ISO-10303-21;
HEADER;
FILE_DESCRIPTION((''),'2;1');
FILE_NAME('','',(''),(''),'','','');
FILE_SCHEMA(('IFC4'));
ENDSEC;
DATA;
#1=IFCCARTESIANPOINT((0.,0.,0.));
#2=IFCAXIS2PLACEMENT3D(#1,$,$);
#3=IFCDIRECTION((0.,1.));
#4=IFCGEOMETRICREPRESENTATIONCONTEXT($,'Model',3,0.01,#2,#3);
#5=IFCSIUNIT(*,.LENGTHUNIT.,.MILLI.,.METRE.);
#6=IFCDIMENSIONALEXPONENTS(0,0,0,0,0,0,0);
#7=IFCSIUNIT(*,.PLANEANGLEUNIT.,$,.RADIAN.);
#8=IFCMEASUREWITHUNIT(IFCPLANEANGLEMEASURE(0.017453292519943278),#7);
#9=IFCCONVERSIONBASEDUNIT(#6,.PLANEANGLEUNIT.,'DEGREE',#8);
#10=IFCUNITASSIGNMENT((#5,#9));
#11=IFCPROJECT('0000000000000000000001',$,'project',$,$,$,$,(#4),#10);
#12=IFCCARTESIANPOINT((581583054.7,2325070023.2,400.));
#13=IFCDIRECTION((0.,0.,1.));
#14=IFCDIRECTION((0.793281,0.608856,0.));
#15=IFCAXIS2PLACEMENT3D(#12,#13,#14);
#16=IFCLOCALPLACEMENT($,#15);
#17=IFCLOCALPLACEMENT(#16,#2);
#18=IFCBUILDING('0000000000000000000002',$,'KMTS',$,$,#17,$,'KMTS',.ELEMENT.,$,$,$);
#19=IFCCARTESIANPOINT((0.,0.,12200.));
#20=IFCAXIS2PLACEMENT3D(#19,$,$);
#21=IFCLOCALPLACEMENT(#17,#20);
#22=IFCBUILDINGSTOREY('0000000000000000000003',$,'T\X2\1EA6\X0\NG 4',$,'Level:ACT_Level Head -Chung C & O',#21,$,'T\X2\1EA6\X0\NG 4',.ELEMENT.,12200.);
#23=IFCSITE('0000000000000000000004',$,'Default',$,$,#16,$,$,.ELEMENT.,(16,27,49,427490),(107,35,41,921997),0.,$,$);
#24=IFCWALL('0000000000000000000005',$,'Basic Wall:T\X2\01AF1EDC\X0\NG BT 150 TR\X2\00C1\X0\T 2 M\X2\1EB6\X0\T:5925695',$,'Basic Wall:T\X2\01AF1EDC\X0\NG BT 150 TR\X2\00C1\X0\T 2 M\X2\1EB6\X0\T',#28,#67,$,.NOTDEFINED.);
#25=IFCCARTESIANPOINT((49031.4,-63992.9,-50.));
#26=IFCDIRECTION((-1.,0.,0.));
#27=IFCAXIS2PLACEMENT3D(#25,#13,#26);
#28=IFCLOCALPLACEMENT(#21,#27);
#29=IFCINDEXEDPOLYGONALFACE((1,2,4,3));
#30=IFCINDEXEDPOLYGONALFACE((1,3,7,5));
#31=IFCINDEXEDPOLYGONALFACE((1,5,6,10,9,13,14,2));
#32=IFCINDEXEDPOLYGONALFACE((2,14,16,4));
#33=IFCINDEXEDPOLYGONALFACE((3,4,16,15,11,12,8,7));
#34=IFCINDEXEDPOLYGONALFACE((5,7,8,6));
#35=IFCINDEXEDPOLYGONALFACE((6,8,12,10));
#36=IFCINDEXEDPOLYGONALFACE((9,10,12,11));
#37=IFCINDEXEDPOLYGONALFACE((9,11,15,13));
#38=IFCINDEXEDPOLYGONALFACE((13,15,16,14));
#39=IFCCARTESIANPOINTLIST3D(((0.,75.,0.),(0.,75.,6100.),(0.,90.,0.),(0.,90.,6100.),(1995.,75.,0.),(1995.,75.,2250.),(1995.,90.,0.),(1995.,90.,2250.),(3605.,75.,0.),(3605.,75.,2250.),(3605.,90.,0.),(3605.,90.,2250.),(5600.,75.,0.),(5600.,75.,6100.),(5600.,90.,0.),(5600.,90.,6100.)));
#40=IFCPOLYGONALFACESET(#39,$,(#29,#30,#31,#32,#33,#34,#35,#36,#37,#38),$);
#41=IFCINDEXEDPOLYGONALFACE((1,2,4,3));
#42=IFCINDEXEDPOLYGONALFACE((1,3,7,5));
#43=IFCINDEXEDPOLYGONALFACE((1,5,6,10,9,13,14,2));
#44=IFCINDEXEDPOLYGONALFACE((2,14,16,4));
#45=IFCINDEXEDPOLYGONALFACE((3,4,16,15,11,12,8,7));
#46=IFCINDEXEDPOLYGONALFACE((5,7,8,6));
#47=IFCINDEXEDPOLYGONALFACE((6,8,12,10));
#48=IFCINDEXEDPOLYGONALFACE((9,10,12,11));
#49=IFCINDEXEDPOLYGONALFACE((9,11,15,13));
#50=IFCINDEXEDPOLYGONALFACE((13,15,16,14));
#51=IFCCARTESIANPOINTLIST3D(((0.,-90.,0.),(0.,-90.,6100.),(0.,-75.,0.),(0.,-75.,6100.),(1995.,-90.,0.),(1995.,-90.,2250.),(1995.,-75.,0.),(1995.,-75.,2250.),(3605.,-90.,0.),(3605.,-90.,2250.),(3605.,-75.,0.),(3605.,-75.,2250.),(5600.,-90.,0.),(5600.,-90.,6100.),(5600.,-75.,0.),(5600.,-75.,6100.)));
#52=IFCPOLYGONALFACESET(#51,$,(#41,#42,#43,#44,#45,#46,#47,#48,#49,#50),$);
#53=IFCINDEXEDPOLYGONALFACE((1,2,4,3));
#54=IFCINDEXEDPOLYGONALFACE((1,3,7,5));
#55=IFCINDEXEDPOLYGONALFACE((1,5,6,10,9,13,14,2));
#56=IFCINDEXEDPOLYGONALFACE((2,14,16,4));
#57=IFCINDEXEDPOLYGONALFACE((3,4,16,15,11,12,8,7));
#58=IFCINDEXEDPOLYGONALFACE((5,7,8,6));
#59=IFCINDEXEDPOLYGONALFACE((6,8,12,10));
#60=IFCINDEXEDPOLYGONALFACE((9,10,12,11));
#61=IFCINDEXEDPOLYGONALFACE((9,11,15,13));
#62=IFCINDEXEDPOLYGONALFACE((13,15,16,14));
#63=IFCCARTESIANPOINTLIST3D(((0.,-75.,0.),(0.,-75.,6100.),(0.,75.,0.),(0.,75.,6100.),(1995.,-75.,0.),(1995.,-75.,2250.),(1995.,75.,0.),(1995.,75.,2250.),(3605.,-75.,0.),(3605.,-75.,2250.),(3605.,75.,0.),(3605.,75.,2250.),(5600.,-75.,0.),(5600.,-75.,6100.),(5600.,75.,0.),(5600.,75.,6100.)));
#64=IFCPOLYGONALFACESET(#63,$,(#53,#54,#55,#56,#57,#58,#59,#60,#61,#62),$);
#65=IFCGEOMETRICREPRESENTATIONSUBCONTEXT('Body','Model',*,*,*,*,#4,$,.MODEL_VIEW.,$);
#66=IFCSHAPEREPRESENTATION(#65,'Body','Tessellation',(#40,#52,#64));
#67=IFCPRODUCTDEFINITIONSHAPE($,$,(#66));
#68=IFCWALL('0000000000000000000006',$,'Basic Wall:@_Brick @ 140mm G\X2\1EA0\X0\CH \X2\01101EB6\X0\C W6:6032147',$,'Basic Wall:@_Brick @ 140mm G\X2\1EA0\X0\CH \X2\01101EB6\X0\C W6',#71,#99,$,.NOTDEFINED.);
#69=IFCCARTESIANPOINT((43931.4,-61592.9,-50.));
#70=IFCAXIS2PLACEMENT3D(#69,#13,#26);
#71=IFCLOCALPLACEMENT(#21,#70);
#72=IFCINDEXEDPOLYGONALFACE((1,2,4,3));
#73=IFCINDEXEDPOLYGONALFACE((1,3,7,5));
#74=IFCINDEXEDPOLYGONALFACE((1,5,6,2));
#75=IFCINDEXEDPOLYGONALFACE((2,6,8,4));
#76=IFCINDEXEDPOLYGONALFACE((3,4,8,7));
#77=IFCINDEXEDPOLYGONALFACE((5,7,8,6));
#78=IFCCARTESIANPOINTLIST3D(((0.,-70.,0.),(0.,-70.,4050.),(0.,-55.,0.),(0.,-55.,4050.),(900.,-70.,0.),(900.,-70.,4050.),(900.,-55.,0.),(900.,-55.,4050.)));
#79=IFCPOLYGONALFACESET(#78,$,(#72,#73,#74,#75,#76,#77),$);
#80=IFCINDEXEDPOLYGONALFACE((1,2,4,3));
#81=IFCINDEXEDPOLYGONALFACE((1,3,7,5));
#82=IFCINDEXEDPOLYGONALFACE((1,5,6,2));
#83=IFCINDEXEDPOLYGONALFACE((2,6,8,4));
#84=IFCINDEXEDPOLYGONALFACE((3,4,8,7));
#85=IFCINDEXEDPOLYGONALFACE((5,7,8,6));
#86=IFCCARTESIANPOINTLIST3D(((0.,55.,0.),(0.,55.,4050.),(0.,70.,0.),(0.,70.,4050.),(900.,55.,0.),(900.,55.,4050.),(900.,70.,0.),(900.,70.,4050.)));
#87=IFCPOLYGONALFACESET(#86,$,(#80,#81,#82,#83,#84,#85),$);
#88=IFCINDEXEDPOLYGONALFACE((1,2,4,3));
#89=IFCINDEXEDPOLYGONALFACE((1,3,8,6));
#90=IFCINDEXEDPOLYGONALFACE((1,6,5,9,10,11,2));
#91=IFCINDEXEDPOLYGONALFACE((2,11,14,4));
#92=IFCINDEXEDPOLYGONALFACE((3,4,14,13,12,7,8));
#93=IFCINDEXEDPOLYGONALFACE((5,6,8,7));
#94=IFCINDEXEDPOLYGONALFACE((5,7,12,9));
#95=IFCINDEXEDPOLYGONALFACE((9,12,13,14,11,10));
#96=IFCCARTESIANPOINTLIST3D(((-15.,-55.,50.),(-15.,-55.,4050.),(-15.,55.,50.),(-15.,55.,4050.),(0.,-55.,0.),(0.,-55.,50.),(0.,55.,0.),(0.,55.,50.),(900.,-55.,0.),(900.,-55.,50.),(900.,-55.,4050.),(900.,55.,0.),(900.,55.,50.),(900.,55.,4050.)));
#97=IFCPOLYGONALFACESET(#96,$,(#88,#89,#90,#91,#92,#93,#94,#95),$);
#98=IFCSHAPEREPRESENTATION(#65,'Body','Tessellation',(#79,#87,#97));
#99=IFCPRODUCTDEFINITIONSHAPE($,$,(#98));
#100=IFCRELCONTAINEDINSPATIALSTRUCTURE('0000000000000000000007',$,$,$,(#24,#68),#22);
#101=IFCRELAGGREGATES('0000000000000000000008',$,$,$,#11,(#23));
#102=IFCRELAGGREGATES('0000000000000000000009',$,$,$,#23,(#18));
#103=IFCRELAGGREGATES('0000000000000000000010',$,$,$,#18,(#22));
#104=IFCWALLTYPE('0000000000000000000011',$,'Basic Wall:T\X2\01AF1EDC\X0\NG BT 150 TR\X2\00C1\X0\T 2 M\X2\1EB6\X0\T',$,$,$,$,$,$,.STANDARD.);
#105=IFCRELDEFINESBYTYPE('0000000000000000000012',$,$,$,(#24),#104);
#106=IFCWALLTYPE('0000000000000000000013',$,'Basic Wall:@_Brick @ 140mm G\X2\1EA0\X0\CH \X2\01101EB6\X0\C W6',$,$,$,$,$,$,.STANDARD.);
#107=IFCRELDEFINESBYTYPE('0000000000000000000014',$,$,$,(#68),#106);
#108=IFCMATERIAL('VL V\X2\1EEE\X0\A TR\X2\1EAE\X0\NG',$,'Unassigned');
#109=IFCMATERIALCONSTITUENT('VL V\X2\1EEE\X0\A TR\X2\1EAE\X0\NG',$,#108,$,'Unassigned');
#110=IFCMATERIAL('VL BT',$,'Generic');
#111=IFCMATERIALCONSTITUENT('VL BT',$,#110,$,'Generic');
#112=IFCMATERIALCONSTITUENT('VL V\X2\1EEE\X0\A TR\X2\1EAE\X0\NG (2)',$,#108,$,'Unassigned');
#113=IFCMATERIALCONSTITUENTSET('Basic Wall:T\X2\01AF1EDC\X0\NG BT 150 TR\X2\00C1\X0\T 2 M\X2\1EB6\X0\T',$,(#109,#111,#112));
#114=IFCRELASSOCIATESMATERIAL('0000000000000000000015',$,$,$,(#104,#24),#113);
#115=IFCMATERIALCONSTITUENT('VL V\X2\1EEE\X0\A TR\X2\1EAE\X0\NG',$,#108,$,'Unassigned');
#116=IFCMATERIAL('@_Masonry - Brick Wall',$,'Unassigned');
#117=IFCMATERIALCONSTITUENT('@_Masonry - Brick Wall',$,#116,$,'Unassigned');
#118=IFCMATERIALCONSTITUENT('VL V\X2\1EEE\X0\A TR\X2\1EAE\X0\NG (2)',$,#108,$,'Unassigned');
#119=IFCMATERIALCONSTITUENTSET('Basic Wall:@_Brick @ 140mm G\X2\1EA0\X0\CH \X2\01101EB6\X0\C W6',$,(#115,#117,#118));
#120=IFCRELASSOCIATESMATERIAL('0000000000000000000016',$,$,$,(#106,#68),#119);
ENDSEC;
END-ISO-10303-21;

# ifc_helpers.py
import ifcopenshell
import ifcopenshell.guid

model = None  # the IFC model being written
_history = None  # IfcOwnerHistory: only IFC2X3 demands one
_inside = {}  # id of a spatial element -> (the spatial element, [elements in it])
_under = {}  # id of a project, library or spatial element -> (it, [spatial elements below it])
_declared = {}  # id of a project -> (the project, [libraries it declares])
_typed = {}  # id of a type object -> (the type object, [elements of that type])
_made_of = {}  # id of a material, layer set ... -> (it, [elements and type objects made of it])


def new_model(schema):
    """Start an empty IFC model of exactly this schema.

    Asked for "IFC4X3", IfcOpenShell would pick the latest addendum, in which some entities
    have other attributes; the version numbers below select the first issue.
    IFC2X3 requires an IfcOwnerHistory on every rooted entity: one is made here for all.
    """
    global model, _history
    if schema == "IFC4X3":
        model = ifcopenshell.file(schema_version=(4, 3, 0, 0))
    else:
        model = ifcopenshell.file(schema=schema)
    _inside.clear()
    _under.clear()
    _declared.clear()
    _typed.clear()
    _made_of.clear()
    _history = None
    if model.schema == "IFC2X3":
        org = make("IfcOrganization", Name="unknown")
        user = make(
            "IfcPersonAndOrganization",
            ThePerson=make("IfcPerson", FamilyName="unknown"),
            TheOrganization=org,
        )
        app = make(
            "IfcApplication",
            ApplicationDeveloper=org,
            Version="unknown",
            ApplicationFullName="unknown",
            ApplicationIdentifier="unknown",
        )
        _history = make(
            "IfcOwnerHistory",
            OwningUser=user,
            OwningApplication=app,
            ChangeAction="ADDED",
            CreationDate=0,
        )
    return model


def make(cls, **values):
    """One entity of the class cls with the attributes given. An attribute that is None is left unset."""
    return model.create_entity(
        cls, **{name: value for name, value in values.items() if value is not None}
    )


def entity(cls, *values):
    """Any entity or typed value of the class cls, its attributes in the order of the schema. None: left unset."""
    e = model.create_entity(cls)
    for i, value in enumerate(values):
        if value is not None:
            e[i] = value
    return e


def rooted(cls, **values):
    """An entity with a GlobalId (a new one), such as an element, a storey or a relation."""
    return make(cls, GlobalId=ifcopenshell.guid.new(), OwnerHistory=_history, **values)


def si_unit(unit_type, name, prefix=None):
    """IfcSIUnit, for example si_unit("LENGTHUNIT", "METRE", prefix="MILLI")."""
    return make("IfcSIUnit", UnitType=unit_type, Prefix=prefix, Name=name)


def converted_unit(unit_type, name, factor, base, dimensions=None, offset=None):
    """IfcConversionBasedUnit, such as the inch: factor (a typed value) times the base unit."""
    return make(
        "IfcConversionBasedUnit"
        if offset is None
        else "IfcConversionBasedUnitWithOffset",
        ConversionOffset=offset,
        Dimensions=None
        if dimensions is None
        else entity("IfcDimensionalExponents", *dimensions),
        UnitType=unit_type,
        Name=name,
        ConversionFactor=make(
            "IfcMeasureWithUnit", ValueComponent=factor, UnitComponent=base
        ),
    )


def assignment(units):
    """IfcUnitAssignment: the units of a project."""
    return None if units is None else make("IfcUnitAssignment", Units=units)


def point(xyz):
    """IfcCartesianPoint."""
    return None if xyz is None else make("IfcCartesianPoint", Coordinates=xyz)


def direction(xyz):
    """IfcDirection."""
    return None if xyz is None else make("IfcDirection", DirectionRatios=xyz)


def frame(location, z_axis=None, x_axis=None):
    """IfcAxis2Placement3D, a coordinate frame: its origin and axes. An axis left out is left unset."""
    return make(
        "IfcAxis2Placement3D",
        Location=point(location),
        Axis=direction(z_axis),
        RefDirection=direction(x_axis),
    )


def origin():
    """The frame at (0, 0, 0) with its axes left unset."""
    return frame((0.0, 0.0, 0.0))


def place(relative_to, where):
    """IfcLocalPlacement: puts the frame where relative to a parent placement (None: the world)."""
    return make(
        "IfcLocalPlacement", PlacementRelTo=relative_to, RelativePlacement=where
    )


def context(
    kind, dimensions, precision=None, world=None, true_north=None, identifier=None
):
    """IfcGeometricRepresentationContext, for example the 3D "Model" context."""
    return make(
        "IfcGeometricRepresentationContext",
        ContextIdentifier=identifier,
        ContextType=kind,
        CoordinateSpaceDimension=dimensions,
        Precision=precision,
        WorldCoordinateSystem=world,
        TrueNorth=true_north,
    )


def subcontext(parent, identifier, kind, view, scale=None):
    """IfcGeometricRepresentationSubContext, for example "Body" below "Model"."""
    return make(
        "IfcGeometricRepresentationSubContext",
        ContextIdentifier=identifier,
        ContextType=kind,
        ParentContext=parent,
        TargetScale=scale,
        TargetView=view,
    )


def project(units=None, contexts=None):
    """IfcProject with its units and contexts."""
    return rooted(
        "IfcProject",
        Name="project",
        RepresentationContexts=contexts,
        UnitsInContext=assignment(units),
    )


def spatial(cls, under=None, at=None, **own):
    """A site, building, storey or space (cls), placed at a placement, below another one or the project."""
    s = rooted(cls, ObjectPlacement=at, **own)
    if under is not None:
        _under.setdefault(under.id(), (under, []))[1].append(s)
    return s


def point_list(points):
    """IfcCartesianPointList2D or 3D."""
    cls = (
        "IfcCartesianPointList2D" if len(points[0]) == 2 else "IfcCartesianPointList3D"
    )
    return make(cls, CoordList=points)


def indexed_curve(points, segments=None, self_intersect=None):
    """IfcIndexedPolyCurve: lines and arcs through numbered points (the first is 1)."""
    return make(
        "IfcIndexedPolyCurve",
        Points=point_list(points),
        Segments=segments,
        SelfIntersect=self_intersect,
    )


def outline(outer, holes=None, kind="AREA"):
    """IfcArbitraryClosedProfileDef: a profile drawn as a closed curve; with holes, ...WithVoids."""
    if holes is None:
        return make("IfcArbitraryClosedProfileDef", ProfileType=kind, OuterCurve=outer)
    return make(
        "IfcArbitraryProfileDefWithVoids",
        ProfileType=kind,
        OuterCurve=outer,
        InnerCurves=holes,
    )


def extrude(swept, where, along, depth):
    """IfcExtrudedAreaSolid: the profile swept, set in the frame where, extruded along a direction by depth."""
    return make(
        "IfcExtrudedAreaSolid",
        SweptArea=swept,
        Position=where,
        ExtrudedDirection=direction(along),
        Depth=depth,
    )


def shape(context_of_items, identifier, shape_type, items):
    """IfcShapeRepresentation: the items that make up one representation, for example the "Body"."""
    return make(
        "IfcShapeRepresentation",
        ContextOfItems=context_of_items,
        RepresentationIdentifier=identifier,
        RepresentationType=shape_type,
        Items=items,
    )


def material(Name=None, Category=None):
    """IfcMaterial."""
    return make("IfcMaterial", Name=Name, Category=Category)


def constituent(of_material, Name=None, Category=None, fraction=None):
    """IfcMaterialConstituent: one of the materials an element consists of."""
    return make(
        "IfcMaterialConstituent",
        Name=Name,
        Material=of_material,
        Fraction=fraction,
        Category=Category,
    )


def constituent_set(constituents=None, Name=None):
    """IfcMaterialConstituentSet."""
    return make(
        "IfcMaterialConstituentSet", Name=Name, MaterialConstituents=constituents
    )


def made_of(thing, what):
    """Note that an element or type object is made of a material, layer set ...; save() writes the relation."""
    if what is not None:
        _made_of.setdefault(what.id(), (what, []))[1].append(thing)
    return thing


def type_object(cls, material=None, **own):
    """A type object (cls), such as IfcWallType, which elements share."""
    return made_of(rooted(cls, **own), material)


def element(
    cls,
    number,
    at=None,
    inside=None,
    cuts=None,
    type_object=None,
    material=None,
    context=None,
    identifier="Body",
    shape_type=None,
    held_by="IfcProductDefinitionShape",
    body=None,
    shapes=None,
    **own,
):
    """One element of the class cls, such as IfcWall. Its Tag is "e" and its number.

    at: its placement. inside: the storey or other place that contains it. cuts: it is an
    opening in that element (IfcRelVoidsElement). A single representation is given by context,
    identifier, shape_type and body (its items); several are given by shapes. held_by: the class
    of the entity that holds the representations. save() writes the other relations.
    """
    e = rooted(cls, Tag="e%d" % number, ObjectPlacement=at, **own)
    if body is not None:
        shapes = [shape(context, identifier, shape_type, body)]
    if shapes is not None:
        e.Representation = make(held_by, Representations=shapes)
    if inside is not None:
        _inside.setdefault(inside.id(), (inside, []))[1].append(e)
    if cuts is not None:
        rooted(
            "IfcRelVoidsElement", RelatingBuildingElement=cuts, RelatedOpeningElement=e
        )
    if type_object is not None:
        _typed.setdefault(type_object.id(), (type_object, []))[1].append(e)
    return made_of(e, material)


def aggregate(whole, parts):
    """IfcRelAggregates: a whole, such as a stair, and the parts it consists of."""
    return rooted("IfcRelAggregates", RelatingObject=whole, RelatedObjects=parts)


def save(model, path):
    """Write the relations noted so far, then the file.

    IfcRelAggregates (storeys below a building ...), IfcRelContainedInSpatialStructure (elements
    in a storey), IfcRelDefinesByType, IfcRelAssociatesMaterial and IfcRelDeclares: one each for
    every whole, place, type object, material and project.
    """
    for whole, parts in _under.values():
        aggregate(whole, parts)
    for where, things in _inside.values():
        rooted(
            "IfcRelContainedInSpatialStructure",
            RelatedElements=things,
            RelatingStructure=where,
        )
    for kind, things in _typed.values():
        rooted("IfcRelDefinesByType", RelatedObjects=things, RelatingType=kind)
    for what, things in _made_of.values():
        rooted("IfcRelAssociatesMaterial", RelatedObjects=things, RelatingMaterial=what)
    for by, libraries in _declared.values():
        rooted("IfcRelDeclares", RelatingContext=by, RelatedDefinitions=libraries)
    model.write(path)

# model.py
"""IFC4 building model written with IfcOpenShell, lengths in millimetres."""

from ifc_helpers import new_model, entity, si_unit, converted_unit, direction, frame, origin, place, context, subcontext, project, spatial, indexed_curve, outline, extrude, material, constituent, constituent_set, type_object, element, save


model = new_model("IFC4")

# Units and contexts
model_context = context("Model", 3, precision=0.01, world=origin(), true_north=direction((0.0, 1.0)))
body_context = subcontext(model_context, "Body", "Model", "MODEL_VIEW")
ifc_project = project(units=[si_unit("LENGTHUNIT", "METRE", prefix="MILLI"), converted_unit("PLANEANGLEUNIT", "DEGREE", entity("IfcPlaneAngleMeasure", 0.017453292519943278), si_unit("PLANEANGLEUNIT", "RADIAN"), dimensions=[0, 0, 0, 0, 0, 0, 0])], contexts=[model_context])

# Site, building, storey
site_placement = place(None, frame((581583054.7, 2325070023.2, 400.0), z_axis=(0.0, 0.0, 1.0), x_axis=(0.793281, 0.608856, 0.0)))
site = spatial("IfcSite", under=ifc_project, at=site_placement, Name="Default", CompositionType="ELEMENT", RefLatitude=(16, 27, 49, 427490), RefLongitude=(107, 35, 41, 921997), RefElevation=0.0)
building_placement = place(site_placement, origin())
building = spatial("IfcBuilding", under=site, at=building_placement, Name="KMTS", LongName="KMTS", CompositionType="ELEMENT")
storey_placement = place(building_placement, frame((0.0, 0.0, 12200.0)))
storey = spatial("IfcBuildingStorey", under=building, at=storey_placement, Name="TẦNG 4", ObjectType="Level:ACT_Level Head -Chung C & O", LongName="TẦNG 4", CompositionType="ELEMENT", Elevation=12200.0)

# Shared definitions
ifc_material_1 = material(Name="VL VỮA TRẮNG", Category="Unassigned")
ifc_constituent_1 = constituent(ifc_material_1, Name="VL VỮA TRẮNG", Category="Unassigned")
ifc_material_2 = material(Name="VL BT", Category="Generic")
ifc_constituent_2 = constituent(ifc_material_2, Name="VL BT", Category="Generic")
ifc_constituent_3 = constituent(ifc_material_1, Name="VL VỮA TRẮNG (2)", Category="Unassigned")
ifc_constituent_set_1 = constituent_set(constituents=[ifc_constituent_1, ifc_constituent_2, ifc_constituent_3], Name="Basic Wall:TƯỜNG BT 150 TRÁT 2 MẶT")
wall_type_1 = type_object("IfcWallType", Name="Basic Wall:TƯỜNG BT 150 TRÁT 2 MẶT", PredefinedType="STANDARD", material=ifc_constituent_set_1)

# Wall, opening
wall_1_placement = place(storey_placement, frame((49031.4, -63992.9, -50.0), z_axis=(0.0, 0.0, 1.0), x_axis=(-1.0, 0.0, 0.0)))
wall_1 = element("IfcWall", 1, at=wall_1_placement, inside=storey, type_object=wall_type_1, material=ifc_constituent_set_1, Name="Basic Wall:TƯỜNG BT 150 TRÁT 2 MẶT:5925695", ObjectType="Basic Wall:TƯỜNG BT 150 TRÁT 2 MẶT", PredefinedType="NOTDEFINED", context=body_context, shape_type="SweptSolid", body=[
    extrude(outline(indexed_curve([(-2087.5, -2800.0), (4012.5, -2800.0), (4012.5, 2800.0), (-2087.5, 2800.0), (-2087.5, 805.0), (162.5, 805.0), (162.5, -805.0), (-2087.5, -805.0), (-2087.5, -2800.0)], self_intersect=False)), frame((2800.0, 90.0, 2087.5), z_axis=(0.0, -1.0, 0.0), x_axis=(0.0, 0.0, 1.0)), (0.0, 0.0, 1.0), 15.0),
    extrude(outline(indexed_curve([(-2087.5, -805.0), (-2087.5, -2800.0), (4012.5, -2800.0), (4012.5, 2800.0), (-2087.5, 2800.0), (-2087.5, 805.0), (162.5, 805.0), (162.5, -805.0), (-2087.5, -805.0)], self_intersect=False)), frame((2800.0, -75.0, 2087.5), z_axis=(0.0, 1.0, 0.0), x_axis=(0.0, 0.0, 1.0)), (0.0, 0.0, -1.0), 15.0),
    extrude(outline(indexed_curve([(-2087.5, -805.0), (-2087.5, -2800.0), (4012.5, -2800.0), (4012.5, 2800.0), (-2087.5, 2800.0), (-2087.5, 805.0), (162.5, 805.0), (162.5, -805.0), (-2087.5, -805.0)], self_intersect=False)), frame((2800.0, 75.0, 2087.5), z_axis=(0.0, 1.0, 0.0), x_axis=(0.0, 0.0, 1.0)), (0.0, 0.0, -1.0), 150.0),
])
opening_1_placement = place(wall_1_placement, frame((3605.0, 90.0, 0.0)))
element("IfcOpeningElement", 2, at=opening_1_placement, cuts=wall_1, PredefinedType="OPENING", context=body_context, shape_type="SweptSolid", body=[
    extrude(outline(indexed_curve([(2250.0, 0.0), (2250.0, 1610.0), (0.0, 1610.0), (0.0, 0.0), (2250.0, 0.0)], self_intersect=False)), frame((0.0, 0.0, 0.0), z_axis=(0.0, -1.0, 0.0), x_axis=(0.0, 0.0, 1.0)), (0.0, 0.0, 1.0), 180.0),
])

# Wall
ifc_constituent_4 = constituent(ifc_material_1, Name="VL VỮA TRẮNG", Category="Unassigned")
ifc_material_3 = material(Name="@_Masonry - Brick Wall", Category="Unassigned")
ifc_constituent_5 = constituent(ifc_material_3, Name="@_Masonry - Brick Wall", Category="Unassigned")
ifc_constituent_6 = constituent(ifc_material_1, Name="VL VỮA TRẮNG (2)", Category="Unassigned")
ifc_constituent_set_2 = constituent_set(constituents=[ifc_constituent_4, ifc_constituent_5, ifc_constituent_6], Name="Basic Wall:@_Brick @ 140mm GẠCH ĐẶC W6")
wall_type_2 = type_object("IfcWallType", Name="Basic Wall:@_Brick @ 140mm GẠCH ĐẶC W6", PredefinedType="STANDARD", material=ifc_constituent_set_2)
wall_2_placement = place(storey_placement, frame((43931.4, -61592.9, -50.0), z_axis=(0.0, 0.0, 1.0), x_axis=(-1.0, 0.0, 0.0)))
element("IfcWall", 3, at=wall_2_placement, inside=storey, type_object=wall_type_2, material=ifc_constituent_set_2, Name="Basic Wall:@_Brick @ 140mm GẠCH ĐẶC W6:6032147", ObjectType="Basic Wall:@_Brick @ 140mm GẠCH ĐẶC W6", PredefinedType="NOTDEFINED", context=body_context, shape_type="SweptSolid", body=[
    extrude(outline(indexed_curve([(-7.5, -450.0), (7.5, -450.0), (7.5, 450.0), (-7.5, 450.0), (-7.5, -450.0)], self_intersect=False)), frame((450.0, -62.5, 0.0), z_axis=(0.0, 0.0, 1.0), x_axis=(0.0, 1.0, 0.0)), (0.0, 0.0, 1.0), 4050.0),
    extrude(outline(indexed_curve([(-7.5, -450.0), (7.5, -450.0), (7.5, 450.0), (-7.5, 450.0), (-7.5, -450.0)], self_intersect=False)), frame((450.0, 62.5, 0.0), z_axis=(0.0, 0.0, 1.0), x_axis=(0.0, -1.0, 0.0)), (0.0, 0.0, 1.0), 4050.0),
    extrude(outline(indexed_curve([(-1178.6, -518.6), (-1128.6, -518.6), (2871.4, -518.6), (2871.4, 396.4), (-1128.6, 396.4), (-1128.6, 381.4), (-1178.6, 381.4), (-1178.6, -518.6)], self_intersect=False)), frame((381.4, 55.0, 1178.6), z_axis=(0.0, -1.0, 0.0), x_axis=(0.0, 0.0, 1.0)), (0.0, 0.0, 1.0), 110.0),
])

save(model, "model.ifc")
